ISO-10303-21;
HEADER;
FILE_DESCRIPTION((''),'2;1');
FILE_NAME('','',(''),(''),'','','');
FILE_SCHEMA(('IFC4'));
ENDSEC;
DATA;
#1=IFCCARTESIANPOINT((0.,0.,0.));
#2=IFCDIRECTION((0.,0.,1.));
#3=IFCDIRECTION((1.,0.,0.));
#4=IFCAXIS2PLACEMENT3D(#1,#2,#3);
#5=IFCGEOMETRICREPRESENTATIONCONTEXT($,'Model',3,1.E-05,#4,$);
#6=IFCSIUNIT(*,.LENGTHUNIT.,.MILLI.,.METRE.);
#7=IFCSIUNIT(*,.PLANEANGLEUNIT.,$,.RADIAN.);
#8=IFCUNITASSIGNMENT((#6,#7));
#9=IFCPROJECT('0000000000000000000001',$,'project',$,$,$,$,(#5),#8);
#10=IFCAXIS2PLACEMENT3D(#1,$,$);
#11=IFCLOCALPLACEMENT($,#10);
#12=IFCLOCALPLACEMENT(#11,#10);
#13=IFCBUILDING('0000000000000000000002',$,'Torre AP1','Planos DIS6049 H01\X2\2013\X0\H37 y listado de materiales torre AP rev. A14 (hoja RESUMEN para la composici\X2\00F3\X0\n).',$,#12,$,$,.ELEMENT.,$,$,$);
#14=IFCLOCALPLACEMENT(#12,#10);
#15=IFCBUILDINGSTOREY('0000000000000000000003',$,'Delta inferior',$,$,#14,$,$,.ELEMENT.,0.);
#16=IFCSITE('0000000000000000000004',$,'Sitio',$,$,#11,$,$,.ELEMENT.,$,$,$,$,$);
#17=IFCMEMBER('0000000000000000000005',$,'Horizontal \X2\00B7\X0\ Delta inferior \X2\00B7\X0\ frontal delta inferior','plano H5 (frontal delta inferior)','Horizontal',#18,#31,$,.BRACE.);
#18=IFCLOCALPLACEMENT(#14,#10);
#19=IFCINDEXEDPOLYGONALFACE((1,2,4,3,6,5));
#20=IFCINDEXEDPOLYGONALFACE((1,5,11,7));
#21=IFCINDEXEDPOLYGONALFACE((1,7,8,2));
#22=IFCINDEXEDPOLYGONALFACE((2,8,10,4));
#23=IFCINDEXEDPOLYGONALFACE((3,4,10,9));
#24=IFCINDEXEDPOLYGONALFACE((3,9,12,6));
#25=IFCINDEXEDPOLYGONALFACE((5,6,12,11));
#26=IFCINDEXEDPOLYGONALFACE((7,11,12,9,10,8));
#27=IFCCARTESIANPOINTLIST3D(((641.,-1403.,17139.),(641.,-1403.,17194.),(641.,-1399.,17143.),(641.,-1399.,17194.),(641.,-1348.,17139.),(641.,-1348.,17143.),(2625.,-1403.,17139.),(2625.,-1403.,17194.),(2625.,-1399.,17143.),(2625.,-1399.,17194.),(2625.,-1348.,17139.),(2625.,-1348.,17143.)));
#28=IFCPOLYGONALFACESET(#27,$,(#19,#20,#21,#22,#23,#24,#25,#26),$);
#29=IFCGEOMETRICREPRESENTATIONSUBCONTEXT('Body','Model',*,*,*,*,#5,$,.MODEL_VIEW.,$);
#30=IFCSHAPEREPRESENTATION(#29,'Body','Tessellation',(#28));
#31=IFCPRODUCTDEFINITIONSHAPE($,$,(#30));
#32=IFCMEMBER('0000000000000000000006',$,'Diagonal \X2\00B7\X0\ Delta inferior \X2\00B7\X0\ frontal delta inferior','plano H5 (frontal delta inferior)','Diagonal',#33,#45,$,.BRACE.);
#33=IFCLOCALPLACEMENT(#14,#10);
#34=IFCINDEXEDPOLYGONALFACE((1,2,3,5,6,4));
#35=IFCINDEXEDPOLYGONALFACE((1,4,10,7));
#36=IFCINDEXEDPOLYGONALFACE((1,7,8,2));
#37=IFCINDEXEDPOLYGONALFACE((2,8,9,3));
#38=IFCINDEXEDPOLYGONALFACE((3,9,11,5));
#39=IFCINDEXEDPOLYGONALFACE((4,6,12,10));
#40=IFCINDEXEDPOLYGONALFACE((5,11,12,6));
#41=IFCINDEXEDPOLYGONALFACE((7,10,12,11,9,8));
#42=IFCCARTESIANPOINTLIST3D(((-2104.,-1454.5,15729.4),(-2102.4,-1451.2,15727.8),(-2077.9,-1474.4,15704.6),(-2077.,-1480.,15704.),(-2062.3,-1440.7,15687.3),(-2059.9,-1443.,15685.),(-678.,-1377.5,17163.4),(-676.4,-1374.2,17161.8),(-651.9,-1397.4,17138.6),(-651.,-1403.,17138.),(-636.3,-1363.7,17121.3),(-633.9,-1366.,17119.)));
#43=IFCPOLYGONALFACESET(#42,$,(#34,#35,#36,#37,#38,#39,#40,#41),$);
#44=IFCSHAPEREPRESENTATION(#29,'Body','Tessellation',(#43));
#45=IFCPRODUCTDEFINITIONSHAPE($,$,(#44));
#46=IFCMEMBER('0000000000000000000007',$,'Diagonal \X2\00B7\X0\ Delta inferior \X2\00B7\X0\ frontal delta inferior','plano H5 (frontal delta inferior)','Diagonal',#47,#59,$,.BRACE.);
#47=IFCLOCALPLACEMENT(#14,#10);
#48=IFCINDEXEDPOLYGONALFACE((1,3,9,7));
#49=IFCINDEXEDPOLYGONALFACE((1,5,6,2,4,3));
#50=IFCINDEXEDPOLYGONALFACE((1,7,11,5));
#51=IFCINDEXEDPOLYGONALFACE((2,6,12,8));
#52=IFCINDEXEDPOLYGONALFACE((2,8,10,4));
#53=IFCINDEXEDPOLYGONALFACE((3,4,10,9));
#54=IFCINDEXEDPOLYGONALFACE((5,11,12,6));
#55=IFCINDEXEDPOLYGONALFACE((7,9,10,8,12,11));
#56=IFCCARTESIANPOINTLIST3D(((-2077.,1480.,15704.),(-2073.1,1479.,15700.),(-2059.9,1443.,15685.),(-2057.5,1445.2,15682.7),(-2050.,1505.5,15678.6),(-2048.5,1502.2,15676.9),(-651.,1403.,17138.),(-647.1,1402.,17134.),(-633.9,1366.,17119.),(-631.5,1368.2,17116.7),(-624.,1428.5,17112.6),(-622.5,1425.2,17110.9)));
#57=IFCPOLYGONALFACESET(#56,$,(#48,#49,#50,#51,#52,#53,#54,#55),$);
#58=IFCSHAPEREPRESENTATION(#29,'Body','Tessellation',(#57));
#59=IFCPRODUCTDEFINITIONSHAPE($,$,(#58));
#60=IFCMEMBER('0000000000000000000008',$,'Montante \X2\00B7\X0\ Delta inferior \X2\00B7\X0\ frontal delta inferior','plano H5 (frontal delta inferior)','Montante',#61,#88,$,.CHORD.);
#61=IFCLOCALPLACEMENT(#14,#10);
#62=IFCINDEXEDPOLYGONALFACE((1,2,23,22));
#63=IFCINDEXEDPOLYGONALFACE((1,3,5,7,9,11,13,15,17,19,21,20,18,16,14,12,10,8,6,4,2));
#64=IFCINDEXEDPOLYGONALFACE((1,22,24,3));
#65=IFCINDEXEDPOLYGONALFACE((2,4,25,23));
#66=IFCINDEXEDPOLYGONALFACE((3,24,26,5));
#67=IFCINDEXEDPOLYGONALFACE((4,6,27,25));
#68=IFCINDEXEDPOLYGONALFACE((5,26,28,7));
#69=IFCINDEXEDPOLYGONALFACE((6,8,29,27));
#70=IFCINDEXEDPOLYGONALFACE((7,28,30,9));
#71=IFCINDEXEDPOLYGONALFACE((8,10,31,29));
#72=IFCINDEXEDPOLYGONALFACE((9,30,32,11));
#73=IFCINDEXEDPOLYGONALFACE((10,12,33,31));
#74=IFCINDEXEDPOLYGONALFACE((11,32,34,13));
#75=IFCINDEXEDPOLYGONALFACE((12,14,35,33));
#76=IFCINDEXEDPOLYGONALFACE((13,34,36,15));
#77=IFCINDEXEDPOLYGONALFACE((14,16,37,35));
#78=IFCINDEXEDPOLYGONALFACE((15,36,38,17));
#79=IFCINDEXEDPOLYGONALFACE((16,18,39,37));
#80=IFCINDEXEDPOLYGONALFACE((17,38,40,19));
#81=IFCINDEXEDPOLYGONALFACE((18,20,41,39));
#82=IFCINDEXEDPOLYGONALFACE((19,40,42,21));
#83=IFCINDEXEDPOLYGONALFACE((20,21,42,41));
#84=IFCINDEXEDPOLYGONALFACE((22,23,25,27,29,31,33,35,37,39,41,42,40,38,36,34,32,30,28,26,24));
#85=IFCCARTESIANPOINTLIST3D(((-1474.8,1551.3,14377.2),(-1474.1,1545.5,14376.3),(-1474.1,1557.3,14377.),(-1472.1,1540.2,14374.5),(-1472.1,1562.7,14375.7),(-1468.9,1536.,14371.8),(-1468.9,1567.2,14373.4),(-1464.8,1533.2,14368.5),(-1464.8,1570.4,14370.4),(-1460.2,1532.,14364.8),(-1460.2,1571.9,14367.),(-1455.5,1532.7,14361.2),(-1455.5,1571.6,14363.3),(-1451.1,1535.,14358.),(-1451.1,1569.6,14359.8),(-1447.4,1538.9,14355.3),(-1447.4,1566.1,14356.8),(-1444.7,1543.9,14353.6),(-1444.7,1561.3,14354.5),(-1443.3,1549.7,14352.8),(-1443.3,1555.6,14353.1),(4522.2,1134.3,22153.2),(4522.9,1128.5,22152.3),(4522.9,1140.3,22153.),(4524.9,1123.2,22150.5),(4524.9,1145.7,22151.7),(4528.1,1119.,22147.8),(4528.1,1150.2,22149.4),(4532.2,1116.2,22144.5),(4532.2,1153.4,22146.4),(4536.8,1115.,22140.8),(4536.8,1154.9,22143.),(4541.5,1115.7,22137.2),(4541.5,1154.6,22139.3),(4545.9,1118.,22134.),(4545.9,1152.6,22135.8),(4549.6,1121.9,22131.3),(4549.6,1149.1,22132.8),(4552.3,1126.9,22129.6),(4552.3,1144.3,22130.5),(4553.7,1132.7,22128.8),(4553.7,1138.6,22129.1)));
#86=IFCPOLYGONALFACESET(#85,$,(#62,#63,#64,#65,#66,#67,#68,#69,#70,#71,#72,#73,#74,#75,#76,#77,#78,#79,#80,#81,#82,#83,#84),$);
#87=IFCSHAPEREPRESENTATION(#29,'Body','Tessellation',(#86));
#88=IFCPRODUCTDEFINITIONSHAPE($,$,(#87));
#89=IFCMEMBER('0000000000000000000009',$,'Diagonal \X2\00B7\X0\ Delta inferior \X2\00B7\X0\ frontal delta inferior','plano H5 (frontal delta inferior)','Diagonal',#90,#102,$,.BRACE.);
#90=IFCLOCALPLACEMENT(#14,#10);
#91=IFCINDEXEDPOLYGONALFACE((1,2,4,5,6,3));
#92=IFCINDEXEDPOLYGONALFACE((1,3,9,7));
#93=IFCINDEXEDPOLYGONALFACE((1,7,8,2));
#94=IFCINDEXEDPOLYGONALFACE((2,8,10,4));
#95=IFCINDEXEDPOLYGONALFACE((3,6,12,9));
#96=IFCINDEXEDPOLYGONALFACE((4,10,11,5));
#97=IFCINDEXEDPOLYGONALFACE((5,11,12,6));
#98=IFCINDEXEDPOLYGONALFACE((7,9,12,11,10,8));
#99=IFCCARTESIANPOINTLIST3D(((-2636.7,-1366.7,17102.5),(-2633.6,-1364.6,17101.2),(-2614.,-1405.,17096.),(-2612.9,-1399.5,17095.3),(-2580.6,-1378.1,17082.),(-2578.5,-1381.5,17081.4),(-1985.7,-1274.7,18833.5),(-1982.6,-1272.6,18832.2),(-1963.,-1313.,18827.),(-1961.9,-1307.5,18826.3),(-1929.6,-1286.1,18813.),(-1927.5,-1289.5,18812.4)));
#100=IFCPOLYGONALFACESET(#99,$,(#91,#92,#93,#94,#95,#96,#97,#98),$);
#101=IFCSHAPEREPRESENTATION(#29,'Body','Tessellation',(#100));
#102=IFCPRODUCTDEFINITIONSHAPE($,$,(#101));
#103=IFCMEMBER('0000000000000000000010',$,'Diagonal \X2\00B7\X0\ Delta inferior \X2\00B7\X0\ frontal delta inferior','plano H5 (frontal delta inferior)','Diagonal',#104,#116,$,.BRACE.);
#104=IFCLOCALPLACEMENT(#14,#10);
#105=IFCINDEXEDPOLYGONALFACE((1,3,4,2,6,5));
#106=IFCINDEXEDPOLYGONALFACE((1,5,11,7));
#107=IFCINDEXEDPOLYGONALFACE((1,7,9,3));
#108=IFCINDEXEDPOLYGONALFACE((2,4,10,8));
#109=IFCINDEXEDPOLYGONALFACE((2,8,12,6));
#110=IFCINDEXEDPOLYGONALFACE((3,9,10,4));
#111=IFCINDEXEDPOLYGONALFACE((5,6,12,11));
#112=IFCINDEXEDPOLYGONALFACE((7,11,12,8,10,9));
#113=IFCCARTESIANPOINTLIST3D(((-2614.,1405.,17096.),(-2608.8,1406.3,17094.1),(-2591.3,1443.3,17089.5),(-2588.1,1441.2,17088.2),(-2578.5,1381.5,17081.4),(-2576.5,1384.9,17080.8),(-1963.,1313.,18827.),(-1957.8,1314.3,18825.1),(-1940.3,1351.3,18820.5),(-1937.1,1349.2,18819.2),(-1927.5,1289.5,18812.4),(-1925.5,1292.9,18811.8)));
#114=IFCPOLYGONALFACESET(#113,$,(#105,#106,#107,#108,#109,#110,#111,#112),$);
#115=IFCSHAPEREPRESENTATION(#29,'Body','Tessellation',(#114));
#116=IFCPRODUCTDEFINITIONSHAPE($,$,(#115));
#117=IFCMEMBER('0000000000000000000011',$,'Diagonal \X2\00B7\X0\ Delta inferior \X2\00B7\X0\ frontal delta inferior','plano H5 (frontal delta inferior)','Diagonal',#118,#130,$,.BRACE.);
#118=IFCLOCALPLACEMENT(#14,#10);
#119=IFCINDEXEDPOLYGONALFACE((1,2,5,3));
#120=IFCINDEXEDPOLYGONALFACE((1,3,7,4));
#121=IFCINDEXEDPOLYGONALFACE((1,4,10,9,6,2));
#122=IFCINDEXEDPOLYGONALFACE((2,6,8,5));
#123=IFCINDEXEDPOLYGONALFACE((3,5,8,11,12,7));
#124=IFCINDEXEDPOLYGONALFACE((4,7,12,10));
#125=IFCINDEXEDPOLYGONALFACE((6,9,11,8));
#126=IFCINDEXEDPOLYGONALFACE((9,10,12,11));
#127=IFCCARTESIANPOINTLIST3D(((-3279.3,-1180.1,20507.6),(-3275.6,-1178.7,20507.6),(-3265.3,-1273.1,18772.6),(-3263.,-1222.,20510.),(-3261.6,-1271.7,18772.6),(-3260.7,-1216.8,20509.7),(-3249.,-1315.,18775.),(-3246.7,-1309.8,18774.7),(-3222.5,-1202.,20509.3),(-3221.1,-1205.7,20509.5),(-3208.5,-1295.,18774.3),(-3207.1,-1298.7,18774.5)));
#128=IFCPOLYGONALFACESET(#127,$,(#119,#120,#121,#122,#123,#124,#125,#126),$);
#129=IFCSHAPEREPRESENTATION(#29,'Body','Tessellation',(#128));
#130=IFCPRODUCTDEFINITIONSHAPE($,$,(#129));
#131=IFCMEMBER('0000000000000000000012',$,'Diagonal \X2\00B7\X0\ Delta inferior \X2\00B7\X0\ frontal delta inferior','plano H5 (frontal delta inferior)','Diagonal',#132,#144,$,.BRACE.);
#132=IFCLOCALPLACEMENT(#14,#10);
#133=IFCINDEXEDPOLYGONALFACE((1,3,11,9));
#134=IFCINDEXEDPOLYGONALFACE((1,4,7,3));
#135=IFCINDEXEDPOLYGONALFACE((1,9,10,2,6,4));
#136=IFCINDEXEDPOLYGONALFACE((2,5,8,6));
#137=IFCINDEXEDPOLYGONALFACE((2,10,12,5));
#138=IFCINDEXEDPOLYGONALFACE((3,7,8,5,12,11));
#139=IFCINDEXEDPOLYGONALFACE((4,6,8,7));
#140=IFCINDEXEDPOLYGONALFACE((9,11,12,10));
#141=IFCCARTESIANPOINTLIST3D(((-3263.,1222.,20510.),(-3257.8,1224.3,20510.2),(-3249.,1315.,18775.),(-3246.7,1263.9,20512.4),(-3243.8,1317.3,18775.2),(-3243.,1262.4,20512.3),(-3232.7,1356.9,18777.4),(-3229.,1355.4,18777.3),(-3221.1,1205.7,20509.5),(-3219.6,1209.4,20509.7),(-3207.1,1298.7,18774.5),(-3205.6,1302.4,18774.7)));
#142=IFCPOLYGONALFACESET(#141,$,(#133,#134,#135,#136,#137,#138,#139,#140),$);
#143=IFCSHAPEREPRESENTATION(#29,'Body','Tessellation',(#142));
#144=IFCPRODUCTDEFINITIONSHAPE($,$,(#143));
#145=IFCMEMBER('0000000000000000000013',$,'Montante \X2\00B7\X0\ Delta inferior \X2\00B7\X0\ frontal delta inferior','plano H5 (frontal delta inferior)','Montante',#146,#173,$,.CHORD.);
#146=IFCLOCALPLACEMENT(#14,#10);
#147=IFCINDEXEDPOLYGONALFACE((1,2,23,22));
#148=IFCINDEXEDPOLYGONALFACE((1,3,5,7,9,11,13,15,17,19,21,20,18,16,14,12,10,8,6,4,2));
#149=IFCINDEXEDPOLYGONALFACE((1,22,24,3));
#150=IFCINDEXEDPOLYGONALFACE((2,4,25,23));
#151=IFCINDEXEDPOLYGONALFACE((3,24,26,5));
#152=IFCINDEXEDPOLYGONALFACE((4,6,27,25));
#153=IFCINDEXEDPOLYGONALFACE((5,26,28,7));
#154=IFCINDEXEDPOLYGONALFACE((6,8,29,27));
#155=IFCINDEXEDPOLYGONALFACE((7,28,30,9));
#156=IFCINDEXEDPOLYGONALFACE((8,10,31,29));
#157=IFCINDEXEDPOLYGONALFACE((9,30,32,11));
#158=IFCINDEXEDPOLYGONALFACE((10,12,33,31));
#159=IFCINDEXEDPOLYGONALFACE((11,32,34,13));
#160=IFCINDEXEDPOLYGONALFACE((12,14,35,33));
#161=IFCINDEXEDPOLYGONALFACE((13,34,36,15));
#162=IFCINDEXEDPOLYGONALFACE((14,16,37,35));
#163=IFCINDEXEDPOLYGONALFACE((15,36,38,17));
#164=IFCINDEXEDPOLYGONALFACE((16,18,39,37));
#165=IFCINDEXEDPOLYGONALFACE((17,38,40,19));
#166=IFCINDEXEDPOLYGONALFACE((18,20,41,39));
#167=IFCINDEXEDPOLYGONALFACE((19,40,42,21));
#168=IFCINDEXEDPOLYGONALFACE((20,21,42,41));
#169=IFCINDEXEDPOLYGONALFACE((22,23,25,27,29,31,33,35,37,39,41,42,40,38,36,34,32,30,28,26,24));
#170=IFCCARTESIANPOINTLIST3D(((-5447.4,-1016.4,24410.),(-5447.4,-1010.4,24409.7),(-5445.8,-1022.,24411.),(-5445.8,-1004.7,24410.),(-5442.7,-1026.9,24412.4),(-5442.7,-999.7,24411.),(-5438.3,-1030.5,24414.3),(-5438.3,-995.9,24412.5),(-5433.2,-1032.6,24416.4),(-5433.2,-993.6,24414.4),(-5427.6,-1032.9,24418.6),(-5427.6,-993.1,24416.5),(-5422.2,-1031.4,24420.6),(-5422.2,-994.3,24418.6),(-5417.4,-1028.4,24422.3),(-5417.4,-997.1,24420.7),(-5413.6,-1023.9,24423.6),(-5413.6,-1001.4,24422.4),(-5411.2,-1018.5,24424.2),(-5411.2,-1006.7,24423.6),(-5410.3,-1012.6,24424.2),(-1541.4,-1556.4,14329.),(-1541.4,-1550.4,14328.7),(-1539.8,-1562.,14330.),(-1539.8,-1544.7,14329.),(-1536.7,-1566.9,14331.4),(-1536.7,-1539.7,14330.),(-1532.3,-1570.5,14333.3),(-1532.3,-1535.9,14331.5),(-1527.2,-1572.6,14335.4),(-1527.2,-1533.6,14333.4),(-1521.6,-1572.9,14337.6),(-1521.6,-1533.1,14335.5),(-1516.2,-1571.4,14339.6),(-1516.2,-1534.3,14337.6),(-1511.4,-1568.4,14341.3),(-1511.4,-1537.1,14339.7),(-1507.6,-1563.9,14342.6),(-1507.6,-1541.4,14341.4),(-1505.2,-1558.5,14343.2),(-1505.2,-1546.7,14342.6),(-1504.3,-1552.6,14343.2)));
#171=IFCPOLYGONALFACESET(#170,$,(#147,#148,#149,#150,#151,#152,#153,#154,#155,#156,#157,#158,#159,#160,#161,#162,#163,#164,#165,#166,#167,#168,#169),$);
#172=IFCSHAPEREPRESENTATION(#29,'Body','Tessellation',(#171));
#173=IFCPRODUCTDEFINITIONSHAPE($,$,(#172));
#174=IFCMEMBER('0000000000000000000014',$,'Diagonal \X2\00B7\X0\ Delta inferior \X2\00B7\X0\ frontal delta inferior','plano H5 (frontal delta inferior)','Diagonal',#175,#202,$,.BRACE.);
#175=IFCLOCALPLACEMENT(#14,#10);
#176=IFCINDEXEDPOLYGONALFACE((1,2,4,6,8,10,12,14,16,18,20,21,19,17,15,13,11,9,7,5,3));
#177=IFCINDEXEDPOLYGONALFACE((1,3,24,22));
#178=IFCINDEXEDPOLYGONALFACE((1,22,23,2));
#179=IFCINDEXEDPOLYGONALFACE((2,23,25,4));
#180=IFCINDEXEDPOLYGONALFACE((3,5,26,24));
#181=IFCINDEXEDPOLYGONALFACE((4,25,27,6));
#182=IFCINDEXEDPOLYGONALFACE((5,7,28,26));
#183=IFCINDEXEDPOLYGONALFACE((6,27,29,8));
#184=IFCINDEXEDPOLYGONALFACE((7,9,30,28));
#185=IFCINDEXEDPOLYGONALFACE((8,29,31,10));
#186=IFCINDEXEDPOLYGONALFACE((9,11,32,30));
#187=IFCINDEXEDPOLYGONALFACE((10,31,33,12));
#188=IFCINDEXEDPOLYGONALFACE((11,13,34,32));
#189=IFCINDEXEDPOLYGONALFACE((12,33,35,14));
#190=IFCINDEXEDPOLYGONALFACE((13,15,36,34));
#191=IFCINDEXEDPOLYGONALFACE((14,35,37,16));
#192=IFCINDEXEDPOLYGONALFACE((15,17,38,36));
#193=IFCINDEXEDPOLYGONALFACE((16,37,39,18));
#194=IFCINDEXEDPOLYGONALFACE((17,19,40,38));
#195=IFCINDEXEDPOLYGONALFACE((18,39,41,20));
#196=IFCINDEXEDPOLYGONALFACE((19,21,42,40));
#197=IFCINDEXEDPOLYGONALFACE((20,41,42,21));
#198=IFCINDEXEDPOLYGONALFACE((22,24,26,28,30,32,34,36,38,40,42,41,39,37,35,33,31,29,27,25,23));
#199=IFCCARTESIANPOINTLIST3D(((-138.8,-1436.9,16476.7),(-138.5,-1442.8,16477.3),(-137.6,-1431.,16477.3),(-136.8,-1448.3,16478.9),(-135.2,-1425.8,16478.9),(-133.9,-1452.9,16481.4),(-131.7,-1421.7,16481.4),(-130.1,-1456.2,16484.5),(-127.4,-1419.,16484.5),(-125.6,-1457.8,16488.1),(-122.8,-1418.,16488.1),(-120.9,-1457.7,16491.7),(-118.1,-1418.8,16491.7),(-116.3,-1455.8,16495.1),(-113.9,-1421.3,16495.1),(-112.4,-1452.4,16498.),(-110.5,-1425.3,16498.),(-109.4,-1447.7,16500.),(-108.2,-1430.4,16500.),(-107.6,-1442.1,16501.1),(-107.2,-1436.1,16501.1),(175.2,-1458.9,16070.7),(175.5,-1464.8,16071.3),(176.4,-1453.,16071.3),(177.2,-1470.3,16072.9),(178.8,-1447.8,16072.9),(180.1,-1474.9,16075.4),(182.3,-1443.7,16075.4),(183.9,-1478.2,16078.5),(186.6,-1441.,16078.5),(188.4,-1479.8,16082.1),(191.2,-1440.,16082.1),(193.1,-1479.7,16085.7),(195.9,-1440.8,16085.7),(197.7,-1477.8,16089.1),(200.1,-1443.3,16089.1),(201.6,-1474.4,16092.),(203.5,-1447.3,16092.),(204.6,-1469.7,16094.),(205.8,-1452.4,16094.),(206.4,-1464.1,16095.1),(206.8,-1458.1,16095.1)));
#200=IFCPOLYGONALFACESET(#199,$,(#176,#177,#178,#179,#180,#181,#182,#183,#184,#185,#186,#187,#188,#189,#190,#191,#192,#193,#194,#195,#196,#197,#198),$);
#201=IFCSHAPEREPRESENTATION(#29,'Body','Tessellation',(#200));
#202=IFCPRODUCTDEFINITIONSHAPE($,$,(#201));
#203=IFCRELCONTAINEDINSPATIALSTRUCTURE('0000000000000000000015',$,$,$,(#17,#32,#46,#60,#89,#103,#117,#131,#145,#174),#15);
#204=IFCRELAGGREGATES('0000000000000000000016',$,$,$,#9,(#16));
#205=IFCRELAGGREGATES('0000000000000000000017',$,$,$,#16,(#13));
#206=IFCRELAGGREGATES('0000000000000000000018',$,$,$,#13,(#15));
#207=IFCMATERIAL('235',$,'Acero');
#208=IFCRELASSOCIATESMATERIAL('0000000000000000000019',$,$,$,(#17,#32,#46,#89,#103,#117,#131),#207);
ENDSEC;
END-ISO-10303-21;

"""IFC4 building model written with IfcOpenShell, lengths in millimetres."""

from ifc_helpers import new_model, si_unit, frame, frame_2d, origin, origin_with_axes, place, context, subcontext, project, spatial, circle, l_section, extrude, material, element, save


model = new_model("IFC4")

# Units and contexts
model_context = context("Model", 3, precision=1e-05, world=origin_with_axes())
body_context = subcontext(model_context, "Body", "Model", "MODEL_VIEW")
ifc_project = project(units=[si_unit("LENGTHUNIT", "METRE", prefix="MILLI"), si_unit("PLANEANGLEUNIT", "RADIAN")], contexts=[model_context])

# Site, building, storey
site_placement = place(None, origin())
site = spatial("IfcSite", under=ifc_project, at=site_placement, Name="Sitio", CompositionType="ELEMENT")
building_placement = place(site_placement, origin())
building = spatial("IfcBuilding", under=site, at=building_placement, Name="Torre AP1", Description="Planos DIS6049 H01–H37 y listado de materiales torre AP rev. A14 (hoja RESUMEN para la composición).", CompositionType="ELEMENT")
storey_placement = place(building_placement, origin())
storey = spatial("IfcBuildingStorey", under=building, at=storey_placement, Name="Delta inferior", CompositionType="ELEMENT", Elevation=0.0)

# Members
ifc_material_1 = material(Name="235", Category="Acero")
member_1_placement = place(storey_placement, frame((641.0, -1403.0, 17139.0), z_axis=(1.0, 0.0, 0.0), x_axis=(0.0, 1.0, 0.0)))
element("IfcMember", 1, at=member_1_placement, inside=storey, material=ifc_material_1, Name="Horizontal · Delta inferior · frontal delta inferior", Description="plano H5 (frontal delta inferior)", ObjectType="Horizontal", PredefinedType="BRACE", context=body_context, shape_type="SweptSolid", body=[
    extrude(l_section(Depth=55.0, Width=55.0, Thickness=4.0, at=frame_2d((27.5, 27.5))), None, (0.0, 0.0, 1.0), 1984.0),
])
for number, where, z_axis, x_axis, name in (
    (2, (-2077.0, -1480.0, 15704.0), (0.704616, 0.038047, 0.708569), (0.380197, 0.822889, -0.422261), "Diagonal · Delta inferior · frontal delta inferior"),
    (3, (-2077.0, 1480.0, 15704.0), (0.704616, -0.038047, 0.708569), (0.380197, -0.822889, -0.422261), "Diagonal · Delta inferior · frontal delta inferior"),
):
    element("IfcMember", number, at=place(storey_placement, frame(where, z_axis=z_axis, x_axis=x_axis)), inside=storey, material=ifc_material_1, Name=name, Description="plano H5 (frontal delta inferior)", ObjectType="Diagonal", PredefinedType="BRACE", context=body_context, shape_type="SweptSolid", body=[
        extrude(l_section(Depth=45.0, Width=45.0, Thickness=4.0, at=frame_2d((22.5, 22.5))), None, (0.0, 0.0, 1.0), 2023.8),
    ])
for number, where, z_axis, x_axis, name in (
    (4, (-1459.0, 1552.0, 14365.0), (0.61015, -0.042427, 0.791149), (-0.792286, -0.032673, 0.609274), "Montante · Delta inferior · frontal delta inferior"),
):
    element("IfcMember", number, at=place(storey_placement, frame(where, z_axis=z_axis, x_axis=x_axis)), inside=storey, Name=name, Description="plano H5 (frontal delta inferior)", ObjectType="Montante", PredefinedType="CHORD", context=body_context, shape_type="SweptSolid", body=[
        extrude(circle(Radius=20.0), None, (0.0, 0.0, 1.0), 9828.7),
    ])
for number, where, z_axis, x_axis, name in (
    (5, (-2614.0, -1405.0, 17096.0), (0.351577, 0.049685, 0.934839), (0.788131, 0.523198, -0.32421), "Diagonal · Delta inferior · frontal delta inferior"),
    (6, (-2614.0, 1405.0, 17096.0), (0.351577, -0.049685, 0.934839), (0.788131, -0.523198, -0.32421), "Diagonal · Delta inferior · frontal delta inferior"),
):
    element("IfcMember", number, at=place(storey_placement, frame(where, z_axis=z_axis, x_axis=x_axis)), inside=storey, material=ifc_material_1, Name=name, Description="plano H5 (frontal delta inferior)", ObjectType="Diagonal", PredefinedType="BRACE", context=body_context, shape_type="SweptSolid", body=[
        extrude(l_section(Depth=45.0, Width=45.0, Thickness=4.0, at=frame_2d((22.5, 22.5))), None, (0.0, 0.0, 1.0), 1851.7),
    ])
for number, where, z_axis, x_axis, name in (
    (7, (-3249.0, -1315.0, 18775.0), (-0.008057, 0.053524, 0.998534), (0.931947, 0.3624, -0.011905), "Diagonal · Delta inferior · frontal delta inferior"),
    (8, (-3249.0, 1315.0, 18775.0), (-0.008057, -0.053524, 0.998534), (0.931947, -0.3624, -0.011905), "Diagonal · Delta inferior · frontal delta inferior"),
):
    element("IfcMember", number, at=place(storey_placement, frame(where, z_axis=z_axis, x_axis=x_axis)), inside=storey, material=ifc_material_1, Name=name, Description="plano H5 (frontal delta inferior)", ObjectType="Diagonal", PredefinedType="BRACE", context=body_context, shape_type="SweptSolid", body=[
        extrude(l_section(Depth=45.0, Width=45.0, Thickness=4.0, at=frame_2d((22.5, 22.5))), None, (0.0, 0.0, 1.0), 1737.5),
    ])
for number, where, z_axis, x_axis, name in (
    (9, (-1523.0, -1553.0, 14336.0), (-0.36084, 0.049886, 0.931293), (0.932628, 0.019301, 0.360324), "Montante · Delta inferior · frontal delta inferior"),
):
    element("IfcMember", number, at=place(storey_placement, frame(where, z_axis=z_axis, x_axis=x_axis)), inside=storey, Name=name, Description="plano H5 (frontal delta inferior)", ObjectType="Montante", PredefinedType="CHORD", context=body_context, shape_type="SweptSolid", body=[
        extrude(circle(Radius=20.0), None, (0.0, 0.0, 1.0), 10824.7),
    ])
for number, where, z_axis, x_axis, name in (
    (10, (191.0, -1460.0, 16083.0), (-0.611219, 0.042824, 0.790302), (0.011492, 0.99891, -0.04524), "Diagonal · Delta inferior · frontal delta inferior"),
):
    element("IfcMember", number, at=place(storey_placement, frame(where, z_axis=z_axis, x_axis=x_axis)), inside=storey, Name=name, Description="plano H5 (frontal delta inferior)", ObjectType="Diagonal", PredefinedType="BRACE", context=body_context, shape_type="SweptSolid", body=[
        extrude(circle(Radius=20.0), None, (0.0, 0.0, 1.0), 513.7),
    ])

save(model, "model.ifc")
